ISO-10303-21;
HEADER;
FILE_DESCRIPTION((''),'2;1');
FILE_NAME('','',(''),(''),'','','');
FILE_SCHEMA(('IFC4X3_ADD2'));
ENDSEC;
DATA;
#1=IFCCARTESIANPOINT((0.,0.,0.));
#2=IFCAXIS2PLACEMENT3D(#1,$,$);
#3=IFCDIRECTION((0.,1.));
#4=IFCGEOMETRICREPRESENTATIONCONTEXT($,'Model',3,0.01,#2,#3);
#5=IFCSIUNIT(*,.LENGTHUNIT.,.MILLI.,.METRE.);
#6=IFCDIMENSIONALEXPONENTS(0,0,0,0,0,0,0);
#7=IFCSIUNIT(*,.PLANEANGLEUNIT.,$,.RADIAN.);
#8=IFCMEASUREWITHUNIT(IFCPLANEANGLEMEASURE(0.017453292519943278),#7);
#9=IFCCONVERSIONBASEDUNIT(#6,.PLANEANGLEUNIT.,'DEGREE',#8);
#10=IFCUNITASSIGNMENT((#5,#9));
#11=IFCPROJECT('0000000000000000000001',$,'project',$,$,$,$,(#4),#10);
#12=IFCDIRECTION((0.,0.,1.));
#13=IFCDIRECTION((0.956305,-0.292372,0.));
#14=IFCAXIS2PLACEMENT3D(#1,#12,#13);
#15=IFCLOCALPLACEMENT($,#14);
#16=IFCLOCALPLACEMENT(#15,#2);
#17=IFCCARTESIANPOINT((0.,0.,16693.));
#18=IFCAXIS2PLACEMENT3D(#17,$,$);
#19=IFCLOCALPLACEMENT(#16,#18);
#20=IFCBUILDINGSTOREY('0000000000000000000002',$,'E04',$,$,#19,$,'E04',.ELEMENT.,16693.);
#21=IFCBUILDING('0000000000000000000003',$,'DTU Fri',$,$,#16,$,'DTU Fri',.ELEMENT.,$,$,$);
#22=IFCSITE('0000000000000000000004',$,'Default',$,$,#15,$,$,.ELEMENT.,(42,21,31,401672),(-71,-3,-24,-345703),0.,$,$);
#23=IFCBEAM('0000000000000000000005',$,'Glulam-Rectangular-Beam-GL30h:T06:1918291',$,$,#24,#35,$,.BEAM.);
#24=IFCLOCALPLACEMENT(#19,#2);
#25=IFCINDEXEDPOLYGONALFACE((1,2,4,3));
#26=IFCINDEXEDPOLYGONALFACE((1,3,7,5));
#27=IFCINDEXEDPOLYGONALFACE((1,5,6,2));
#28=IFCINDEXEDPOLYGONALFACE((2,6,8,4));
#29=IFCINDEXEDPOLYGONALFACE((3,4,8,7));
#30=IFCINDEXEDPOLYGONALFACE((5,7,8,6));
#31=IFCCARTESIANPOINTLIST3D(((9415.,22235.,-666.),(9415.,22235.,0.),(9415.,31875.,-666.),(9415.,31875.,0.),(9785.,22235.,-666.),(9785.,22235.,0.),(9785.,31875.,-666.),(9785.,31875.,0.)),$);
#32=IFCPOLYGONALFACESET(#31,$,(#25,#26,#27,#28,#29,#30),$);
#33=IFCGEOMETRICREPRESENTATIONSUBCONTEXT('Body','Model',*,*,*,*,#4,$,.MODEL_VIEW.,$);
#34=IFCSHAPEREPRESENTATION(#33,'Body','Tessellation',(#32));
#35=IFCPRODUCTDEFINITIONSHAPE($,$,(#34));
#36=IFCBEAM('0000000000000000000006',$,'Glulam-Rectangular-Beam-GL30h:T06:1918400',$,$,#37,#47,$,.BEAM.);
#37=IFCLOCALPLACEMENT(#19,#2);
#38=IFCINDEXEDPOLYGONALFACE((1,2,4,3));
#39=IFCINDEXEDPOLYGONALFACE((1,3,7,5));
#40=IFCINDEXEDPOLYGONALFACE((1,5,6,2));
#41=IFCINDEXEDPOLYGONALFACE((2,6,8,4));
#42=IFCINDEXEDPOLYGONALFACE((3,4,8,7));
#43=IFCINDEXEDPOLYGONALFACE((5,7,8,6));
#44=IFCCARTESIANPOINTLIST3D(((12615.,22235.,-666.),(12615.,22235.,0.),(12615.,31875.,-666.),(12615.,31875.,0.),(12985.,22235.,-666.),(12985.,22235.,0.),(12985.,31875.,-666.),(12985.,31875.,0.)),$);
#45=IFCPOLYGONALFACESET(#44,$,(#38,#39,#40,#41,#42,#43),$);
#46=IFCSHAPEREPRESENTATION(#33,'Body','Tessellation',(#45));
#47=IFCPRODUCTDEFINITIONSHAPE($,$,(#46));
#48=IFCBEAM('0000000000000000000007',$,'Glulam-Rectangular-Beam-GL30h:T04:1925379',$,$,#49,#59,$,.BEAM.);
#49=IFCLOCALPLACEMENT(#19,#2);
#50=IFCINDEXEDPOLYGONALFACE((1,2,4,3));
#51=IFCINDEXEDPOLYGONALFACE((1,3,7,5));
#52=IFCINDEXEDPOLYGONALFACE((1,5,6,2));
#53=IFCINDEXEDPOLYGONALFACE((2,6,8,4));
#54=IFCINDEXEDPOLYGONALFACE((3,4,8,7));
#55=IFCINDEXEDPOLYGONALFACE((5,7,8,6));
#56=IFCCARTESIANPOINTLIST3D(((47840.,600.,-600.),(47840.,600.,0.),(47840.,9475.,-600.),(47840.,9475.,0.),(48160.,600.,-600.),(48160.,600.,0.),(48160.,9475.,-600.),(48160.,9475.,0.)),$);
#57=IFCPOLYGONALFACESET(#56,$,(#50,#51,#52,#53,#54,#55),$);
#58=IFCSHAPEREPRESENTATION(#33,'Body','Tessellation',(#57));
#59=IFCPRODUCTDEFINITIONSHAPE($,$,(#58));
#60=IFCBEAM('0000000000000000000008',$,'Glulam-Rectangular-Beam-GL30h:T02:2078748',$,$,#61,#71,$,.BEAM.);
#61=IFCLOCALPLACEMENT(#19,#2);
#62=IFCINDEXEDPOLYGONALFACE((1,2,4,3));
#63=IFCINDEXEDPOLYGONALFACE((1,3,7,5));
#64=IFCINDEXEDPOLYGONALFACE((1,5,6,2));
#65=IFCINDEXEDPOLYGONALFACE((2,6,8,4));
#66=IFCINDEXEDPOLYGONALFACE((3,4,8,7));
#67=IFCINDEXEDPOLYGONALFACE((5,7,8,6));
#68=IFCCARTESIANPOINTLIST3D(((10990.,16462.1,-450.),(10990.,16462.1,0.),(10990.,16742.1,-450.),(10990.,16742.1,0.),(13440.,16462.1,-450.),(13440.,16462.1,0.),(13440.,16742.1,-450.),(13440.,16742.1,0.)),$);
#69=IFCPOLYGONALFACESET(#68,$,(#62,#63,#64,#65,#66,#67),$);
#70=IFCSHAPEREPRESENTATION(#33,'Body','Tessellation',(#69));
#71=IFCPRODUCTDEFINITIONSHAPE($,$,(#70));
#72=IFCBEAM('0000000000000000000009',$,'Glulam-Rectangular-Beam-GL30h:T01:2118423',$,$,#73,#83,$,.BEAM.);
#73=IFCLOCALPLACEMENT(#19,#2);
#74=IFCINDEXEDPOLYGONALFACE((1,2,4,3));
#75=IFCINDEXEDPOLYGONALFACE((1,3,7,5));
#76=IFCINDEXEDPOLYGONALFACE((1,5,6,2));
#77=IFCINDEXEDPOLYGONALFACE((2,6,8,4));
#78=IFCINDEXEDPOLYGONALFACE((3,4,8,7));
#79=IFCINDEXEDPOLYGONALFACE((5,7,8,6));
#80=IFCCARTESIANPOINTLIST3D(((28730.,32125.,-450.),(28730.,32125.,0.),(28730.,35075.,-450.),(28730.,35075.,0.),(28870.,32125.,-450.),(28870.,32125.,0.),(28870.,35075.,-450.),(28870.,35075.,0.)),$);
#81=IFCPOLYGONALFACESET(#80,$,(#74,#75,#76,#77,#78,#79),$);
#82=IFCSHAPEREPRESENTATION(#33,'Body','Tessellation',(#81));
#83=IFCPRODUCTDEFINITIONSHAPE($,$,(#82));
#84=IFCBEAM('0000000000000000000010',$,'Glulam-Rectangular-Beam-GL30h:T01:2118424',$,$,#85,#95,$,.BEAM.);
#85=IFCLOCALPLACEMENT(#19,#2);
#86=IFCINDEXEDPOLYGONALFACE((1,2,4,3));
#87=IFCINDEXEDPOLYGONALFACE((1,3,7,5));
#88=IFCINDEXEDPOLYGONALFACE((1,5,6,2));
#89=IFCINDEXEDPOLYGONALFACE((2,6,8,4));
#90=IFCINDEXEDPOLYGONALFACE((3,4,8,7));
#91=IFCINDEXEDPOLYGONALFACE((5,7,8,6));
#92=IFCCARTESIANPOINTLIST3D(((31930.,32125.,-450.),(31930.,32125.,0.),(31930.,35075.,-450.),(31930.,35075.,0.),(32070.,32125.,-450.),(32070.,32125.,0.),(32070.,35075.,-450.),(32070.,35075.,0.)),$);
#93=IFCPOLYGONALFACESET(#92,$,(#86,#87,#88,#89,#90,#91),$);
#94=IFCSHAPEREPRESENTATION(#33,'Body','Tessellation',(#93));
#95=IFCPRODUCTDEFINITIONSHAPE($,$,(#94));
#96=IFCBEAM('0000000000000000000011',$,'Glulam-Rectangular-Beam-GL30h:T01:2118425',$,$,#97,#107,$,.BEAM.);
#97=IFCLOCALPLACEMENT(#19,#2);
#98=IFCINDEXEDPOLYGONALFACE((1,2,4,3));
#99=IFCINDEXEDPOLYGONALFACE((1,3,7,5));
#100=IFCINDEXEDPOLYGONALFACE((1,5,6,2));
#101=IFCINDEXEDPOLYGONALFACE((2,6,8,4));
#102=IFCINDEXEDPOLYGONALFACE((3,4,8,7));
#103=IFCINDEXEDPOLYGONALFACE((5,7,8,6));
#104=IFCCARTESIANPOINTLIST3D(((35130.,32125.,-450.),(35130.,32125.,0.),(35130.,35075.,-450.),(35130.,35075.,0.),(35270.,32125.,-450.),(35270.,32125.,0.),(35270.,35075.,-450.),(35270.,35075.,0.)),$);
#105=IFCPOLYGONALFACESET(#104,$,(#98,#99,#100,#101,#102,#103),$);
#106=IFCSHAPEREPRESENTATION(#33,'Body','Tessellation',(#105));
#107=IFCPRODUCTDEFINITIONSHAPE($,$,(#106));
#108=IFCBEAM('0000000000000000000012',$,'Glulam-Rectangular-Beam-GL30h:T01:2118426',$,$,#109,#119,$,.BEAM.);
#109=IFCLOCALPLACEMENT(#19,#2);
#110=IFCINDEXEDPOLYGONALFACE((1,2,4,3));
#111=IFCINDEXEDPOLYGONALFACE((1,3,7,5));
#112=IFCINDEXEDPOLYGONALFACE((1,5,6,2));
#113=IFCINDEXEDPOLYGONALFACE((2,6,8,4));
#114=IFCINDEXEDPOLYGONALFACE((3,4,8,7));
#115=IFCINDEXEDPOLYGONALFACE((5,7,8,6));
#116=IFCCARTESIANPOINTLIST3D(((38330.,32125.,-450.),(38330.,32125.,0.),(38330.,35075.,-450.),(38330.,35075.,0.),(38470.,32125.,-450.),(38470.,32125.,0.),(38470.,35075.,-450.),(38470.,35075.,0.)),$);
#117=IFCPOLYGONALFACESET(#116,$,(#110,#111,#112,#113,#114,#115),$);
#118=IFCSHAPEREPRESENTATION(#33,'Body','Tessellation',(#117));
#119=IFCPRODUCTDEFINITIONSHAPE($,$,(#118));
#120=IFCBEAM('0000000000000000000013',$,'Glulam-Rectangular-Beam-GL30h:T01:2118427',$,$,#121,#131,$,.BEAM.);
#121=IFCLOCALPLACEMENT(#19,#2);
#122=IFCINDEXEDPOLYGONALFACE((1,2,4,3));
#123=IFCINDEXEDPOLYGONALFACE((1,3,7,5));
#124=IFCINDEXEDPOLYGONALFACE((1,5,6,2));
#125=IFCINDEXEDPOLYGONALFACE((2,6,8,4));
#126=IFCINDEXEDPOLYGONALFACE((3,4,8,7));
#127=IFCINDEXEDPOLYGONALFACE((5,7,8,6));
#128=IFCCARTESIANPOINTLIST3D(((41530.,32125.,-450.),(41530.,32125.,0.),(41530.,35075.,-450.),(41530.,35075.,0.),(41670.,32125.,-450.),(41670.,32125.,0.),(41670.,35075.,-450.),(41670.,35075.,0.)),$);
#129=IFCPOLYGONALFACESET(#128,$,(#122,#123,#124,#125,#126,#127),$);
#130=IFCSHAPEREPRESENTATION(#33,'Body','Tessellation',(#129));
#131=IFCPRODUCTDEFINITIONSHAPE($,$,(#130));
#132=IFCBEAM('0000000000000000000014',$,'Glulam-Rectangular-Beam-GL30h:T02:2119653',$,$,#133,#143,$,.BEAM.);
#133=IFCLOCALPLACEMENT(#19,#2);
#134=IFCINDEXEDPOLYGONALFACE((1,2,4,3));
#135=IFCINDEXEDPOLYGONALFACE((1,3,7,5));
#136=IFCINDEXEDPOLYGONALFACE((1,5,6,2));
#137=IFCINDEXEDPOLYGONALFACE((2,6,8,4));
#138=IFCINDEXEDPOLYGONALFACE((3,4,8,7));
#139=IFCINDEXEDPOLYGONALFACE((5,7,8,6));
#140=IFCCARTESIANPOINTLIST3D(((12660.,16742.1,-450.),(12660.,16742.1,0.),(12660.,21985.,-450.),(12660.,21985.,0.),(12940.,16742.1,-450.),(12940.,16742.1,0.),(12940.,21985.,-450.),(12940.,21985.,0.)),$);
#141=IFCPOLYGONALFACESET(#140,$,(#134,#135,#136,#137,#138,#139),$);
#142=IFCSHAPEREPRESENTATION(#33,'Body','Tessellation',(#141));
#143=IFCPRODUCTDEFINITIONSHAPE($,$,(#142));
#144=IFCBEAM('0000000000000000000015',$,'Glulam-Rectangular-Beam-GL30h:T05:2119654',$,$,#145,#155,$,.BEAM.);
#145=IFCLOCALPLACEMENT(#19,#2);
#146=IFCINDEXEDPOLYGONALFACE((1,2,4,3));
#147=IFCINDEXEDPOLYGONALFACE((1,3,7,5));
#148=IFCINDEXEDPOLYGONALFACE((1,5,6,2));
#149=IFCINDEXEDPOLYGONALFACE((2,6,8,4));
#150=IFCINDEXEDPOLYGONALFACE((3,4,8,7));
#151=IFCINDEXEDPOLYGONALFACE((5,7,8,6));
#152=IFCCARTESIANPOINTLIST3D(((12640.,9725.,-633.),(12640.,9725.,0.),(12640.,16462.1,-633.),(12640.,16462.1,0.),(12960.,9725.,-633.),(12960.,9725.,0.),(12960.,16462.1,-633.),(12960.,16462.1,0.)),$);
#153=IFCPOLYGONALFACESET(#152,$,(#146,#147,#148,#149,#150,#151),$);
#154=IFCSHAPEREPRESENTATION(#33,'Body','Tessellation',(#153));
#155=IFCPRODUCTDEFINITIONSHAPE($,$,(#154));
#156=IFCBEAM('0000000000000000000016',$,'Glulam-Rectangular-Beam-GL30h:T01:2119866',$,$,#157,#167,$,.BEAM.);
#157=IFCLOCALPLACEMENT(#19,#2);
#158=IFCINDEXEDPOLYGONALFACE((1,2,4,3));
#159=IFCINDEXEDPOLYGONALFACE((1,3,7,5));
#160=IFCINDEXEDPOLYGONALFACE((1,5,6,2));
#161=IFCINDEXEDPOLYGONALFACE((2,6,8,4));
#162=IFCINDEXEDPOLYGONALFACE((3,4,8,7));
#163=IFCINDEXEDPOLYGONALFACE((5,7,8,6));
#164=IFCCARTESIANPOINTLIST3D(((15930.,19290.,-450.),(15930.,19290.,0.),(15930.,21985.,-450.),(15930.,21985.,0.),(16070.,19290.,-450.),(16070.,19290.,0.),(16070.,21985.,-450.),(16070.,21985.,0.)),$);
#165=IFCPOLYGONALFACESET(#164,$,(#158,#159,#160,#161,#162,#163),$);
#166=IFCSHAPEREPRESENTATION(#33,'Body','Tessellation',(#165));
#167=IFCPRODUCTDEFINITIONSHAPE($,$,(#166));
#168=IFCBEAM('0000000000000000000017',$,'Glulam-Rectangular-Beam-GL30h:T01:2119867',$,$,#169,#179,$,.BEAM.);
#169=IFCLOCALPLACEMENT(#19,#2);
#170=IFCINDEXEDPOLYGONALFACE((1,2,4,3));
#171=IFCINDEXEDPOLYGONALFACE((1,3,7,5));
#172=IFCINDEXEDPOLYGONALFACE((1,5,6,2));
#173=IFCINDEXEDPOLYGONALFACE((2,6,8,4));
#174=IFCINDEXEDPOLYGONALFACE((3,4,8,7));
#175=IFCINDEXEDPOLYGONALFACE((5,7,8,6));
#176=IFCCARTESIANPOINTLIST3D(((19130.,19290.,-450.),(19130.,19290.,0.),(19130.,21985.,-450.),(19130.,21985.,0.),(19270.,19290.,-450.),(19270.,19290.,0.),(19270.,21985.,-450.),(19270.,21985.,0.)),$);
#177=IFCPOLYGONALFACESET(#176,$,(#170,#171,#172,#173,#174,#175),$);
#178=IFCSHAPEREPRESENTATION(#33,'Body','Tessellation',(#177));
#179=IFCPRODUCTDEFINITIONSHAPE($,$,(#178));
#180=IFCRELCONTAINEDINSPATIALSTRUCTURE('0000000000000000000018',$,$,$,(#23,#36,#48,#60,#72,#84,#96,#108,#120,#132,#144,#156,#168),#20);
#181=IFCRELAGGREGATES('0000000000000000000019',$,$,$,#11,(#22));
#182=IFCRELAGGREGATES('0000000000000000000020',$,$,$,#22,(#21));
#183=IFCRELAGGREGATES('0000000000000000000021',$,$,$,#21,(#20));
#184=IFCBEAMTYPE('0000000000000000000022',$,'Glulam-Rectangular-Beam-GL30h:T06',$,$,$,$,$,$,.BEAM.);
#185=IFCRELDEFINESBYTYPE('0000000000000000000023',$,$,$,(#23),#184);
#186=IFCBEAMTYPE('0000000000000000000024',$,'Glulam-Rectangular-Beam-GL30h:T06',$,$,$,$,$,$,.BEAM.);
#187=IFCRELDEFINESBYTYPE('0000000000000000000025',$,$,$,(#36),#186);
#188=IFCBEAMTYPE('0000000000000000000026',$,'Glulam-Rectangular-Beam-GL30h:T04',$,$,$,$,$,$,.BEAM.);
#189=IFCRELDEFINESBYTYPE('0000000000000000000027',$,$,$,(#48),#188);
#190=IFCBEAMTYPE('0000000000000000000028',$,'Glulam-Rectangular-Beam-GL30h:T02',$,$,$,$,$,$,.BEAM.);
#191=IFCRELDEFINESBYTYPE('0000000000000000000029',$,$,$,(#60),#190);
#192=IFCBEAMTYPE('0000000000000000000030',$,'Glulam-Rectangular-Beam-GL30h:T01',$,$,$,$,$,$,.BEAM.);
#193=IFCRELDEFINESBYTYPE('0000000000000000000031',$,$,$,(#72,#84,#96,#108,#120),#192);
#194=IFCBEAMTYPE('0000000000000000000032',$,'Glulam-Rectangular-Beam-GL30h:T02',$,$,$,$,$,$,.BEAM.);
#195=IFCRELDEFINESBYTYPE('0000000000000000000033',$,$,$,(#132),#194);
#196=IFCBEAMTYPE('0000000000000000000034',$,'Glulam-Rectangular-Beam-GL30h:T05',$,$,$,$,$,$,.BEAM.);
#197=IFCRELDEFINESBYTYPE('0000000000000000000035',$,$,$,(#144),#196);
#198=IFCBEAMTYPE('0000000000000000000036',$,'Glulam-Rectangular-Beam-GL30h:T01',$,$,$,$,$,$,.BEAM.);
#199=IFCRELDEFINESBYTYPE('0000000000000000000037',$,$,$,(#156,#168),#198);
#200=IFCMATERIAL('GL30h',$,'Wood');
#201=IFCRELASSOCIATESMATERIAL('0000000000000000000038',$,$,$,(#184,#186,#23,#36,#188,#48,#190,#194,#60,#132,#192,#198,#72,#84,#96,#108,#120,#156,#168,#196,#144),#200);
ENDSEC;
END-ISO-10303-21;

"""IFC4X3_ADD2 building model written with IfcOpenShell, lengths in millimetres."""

from ifc_helpers import new_model, entity, si_unit, converted_unit, direction, frame, origin, origin_2d_with_axis, place, context, subcontext, project, spatial, rectangle, extrude, source, transform, mapped, material, material_profile, profile_set, profile_usage, type_object, type_shapes, element, save


model = new_model("IFC4X3_ADD2")

# Units and contexts
model_context = context("Model", 3, precision=0.01, world=origin(), true_north=direction((0.0, 1.0)))
body_context = subcontext(model_context, "Body", "Model", "MODEL_VIEW")
ifc_project = project(units=[si_unit("LENGTHUNIT", "METRE", prefix="MILLI"), converted_unit("PLANEANGLEUNIT", "DEGREE", entity("IfcPlaneAngleMeasure", 0.017453292519943278), si_unit("PLANEANGLEUNIT", "RADIAN"), dimensions=[0, 0, 0, 0, 0, 0, 0])], contexts=[model_context])

# Site, building, storey
site_placement = place(None, frame((0.0, 0.0, 0.0), z_axis=(0.0, 0.0, 1.0), x_axis=(0.956305, -0.292372, 0.0)))
site = spatial("IfcSite", under=ifc_project, at=site_placement, Name="Default", CompositionType="ELEMENT", RefLatitude=(42, 21, 31, 401672), RefLongitude=(-71, -3, -24, -345703), RefElevation=0.0)
building_placement = place(site_placement, origin())
building = spatial("IfcBuilding", under=site, at=building_placement, Name="DTU Fri", LongName="DTU Fri", CompositionType="ELEMENT")
storey_placement = place(building_placement, frame((0.0, 0.0, 16693.0)))
storey = spatial("IfcBuildingStorey", under=building, at=storey_placement, Name="E04", LongName="E04", CompositionType="ELEMENT", Elevation=16693.0)

# Beams
ifc_material = material(Name="GL30h", Category="Wood")
ifc_material_profile_1 = material_profile(ifc_material, rectangle(XDim=666.0, YDim=370.0, at=origin_2d_with_axis()), Name="T06")
ifc_profile_set_1 = profile_set([ifc_material_profile_1], Name="T06")
ifc_profile_usage_1 = profile_usage(ifc_profile_set_1, cardinal=8)
beam_type_1 = type_object("IfcBeamType", Name="Glulam-Rectangular-Beam-GL30h:T06", PredefinedType="BEAM", material=ifc_profile_set_1)
shared_shape_1 = source(origin(), body_context, "Body", "SweptSolid", [
    extrude(rectangle(XDim=666.0, YDim=370.0, at=origin_2d_with_axis()), frame((-4820.0, 0.0, 0.0), z_axis=(1.0, 0.0, 0.0), x_axis=(0.0, 0.0, -1.0)), (0.0, 0.0, 1.0), 9640.0),
])
type_shapes(beam_type_1, [shared_shape_1])
beam_1_placement = place(storey_placement, frame((9600.0, 27055.0, -333.0), z_axis=(0.0, 0.0, 1.0), x_axis=(0.0, -1.0, 0.0)))
element("IfcBeam", 1, at=beam_1_placement, inside=storey, type_object=beam_type_1, material=ifc_profile_usage_1, Name="Glulam-Rectangular-Beam-GL30h:T06:1918291", PredefinedType="BEAM", context=body_context, shape_type="MappedRepresentation", body=[
    mapped(shared_shape_1, transform((0.0, 0.0, 0.0), scale=1.0)),
])
beam_type_2 = type_object("IfcBeamType", Name="Glulam-Rectangular-Beam-GL30h:T06", PredefinedType="BEAM", material=ifc_profile_set_1)
shared_shape_2 = source(origin(), body_context, "Body", "SweptSolid", [
    extrude(rectangle(XDim=666.0, YDim=370.0, at=origin_2d_with_axis()), frame((-4768.7, 0.0, 0.0), z_axis=(1.0, 0.0, 0.0), x_axis=(0.0, 0.0, -1.0)), (0.0, 0.0, 1.0), 9640.0),
])
type_shapes(beam_type_2, [shared_shape_2])
beam_2_placement = place(storey_placement, frame((12800.0, 27106.3, -333.0), z_axis=(0.0, 0.0, 1.0), x_axis=(-0.000004, -1.0, 0.0)))
element("IfcBeam", 2, at=beam_2_placement, inside=storey, type_object=beam_type_2, material=ifc_profile_usage_1, Name="Glulam-Rectangular-Beam-GL30h:T06:1918400", PredefinedType="BEAM", context=body_context, shape_type="MappedRepresentation", body=[
    mapped(shared_shape_2, transform((0.0, 0.0, 0.0), scale=1.0)),
])
ifc_material_profile_2 = material_profile(ifc_material, rectangle(XDim=600.0, YDim=320.0, at=origin_2d_with_axis()), Name="T04")
ifc_profile_set_2 = profile_set([ifc_material_profile_2], Name="T04")
ifc_profile_usage_2 = profile_usage(ifc_profile_set_2, cardinal=8)
beam_type_3 = type_object("IfcBeamType", Name="Glulam-Rectangular-Beam-GL30h:T04", PredefinedType="BEAM", material=ifc_profile_set_2)
shared_shape_3 = source(origin(), body_context, "Body", "SweptSolid", [
    extrude(rectangle(XDim=600.0, YDim=320.0, at=origin_2d_with_axis()), frame((-4425.0, 0.0, 0.0), z_axis=(1.0, 0.0, 0.0), x_axis=(0.0, 0.0, -1.0)), (0.0, 0.0, 1.0), 8875.0),
])
type_shapes(beam_type_3, [shared_shape_3])
beam_3_placement = place(storey_placement, frame((48000.0, 5050.0, -300.0), z_axis=(0.0, 0.0, 1.0), x_axis=(0.0, -1.0, 0.0)))
element("IfcBeam", 3, at=beam_3_placement, inside=storey, type_object=beam_type_3, material=ifc_profile_usage_2, Name="Glulam-Rectangular-Beam-GL30h:T04:1925379", PredefinedType="BEAM", context=body_context, shape_type="MappedRepresentation", body=[
    mapped(shared_shape_3, transform((0.0, 0.0, 0.0), scale=1.0)),
])
ifc_material_profile_3 = material_profile(ifc_material, rectangle(XDim=450.0, YDim=280.0, at=origin_2d_with_axis()), Name="T02")
ifc_profile_set_3 = profile_set([ifc_material_profile_3], Name="T02")
ifc_profile_usage_3 = profile_usage(ifc_profile_set_3, cardinal=8)
beam_type_4 = type_object("IfcBeamType", Name="Glulam-Rectangular-Beam-GL30h:T02", PredefinedType="BEAM", material=ifc_profile_set_3)
shared_shape_4 = source(origin(), body_context, "Body", "SweptSolid", [
    extrude(rectangle(XDim=450.0, YDim=280.0, at=origin_2d_with_axis()), frame((-1225.0, 0.0, 0.0), z_axis=(1.0, 0.0, 0.0), x_axis=(0.0, 0.0, -1.0)), (0.0, 0.0, 1.0), 2450.0),
])
type_shapes(beam_type_4, [shared_shape_4])
beam_4_placement = place(storey_placement, frame((12215.0, 16602.1, -225.0), z_axis=(0.0, 0.0, 1.0), x_axis=(-1.0, 0.0, 0.0)))
element("IfcBeam", 4, at=beam_4_placement, inside=storey, type_object=beam_type_4, material=ifc_profile_usage_3, Name="Glulam-Rectangular-Beam-GL30h:T02:2078748", PredefinedType="BEAM", context=body_context, shape_type="MappedRepresentation", body=[
    mapped(shared_shape_4, transform((0.0, 0.0, 0.0), scale=1.0)),
])
ifc_material_profile_4 = material_profile(ifc_material, rectangle(XDim=450.0, YDim=140.0, at=origin_2d_with_axis()), Name="T01")
ifc_profile_set_4 = profile_set([ifc_material_profile_4], Name="T01")
ifc_profile_usage_4 = profile_usage(ifc_profile_set_4, cardinal=8)
beam_type_5 = type_object("IfcBeamType", Name="Glulam-Rectangular-Beam-GL30h:T01", PredefinedType="BEAM", material=ifc_profile_set_4)
shared_shape_5 = source(origin(), body_context, "Body", "SweptSolid", [
    extrude(rectangle(XDim=450.0, YDim=140.0, at=origin_2d_with_axis()), frame((-1475.0, 0.0, 0.0), z_axis=(1.0, 0.0, 0.0), x_axis=(0.0, 0.0, -1.0)), (0.0, 0.0, 1.0), 2950.0),
])
type_shapes(beam_type_5, [shared_shape_5])
for number, where, z_axis, x_axis, name in (
    (5, (28800.0, 33600.0, -225.0), (0.0, 0.0, 1.0), (0.0, 1.0, 0.0), "Glulam-Rectangular-Beam-GL30h:T01:2118423"),
    (6, (32000.0, 33600.0, -225.0), (0.0, 0.0, 1.0), (0.0, 1.0, 0.0), "Glulam-Rectangular-Beam-GL30h:T01:2118424"),
    (7, (35200.0, 33600.0, -225.0), (0.0, 0.0, 1.0), (0.0, 1.0, 0.0), "Glulam-Rectangular-Beam-GL30h:T01:2118425"),
    (8, (38400.0, 33600.0, -225.0), (0.0, 0.0, 1.0), (0.0, 1.0, 0.0), "Glulam-Rectangular-Beam-GL30h:T01:2118426"),
    (9, (41600.0, 33600.0, -225.0), (0.0, 0.0, 1.0), (0.0, 1.0, 0.0), "Glulam-Rectangular-Beam-GL30h:T01:2118427"),
):
    element("IfcBeam", number, at=place(storey_placement, frame(where, z_axis=z_axis, x_axis=x_axis)), inside=storey, type_object=beam_type_5, material=ifc_profile_usage_4, Name=name, PredefinedType="BEAM", context=body_context, shape_type="MappedRepresentation", body=[
        mapped(shared_shape_5, transform((0.0, 0.0, 0.0), scale=1.0)),
    ])
beam_type_6 = type_object("IfcBeamType", Name="Glulam-Rectangular-Beam-GL30h:T02", PredefinedType="BEAM", material=ifc_profile_set_3)
shared_shape_6 = source(origin(), body_context, "Body", "SweptSolid", [
    extrude(rectangle(XDim=450.0, YDim=280.0, at=origin_2d_with_axis()), frame((-2614.0, 0.0, 0.0), z_axis=(1.0, 0.0, 0.0), x_axis=(0.0, 0.0, -1.0)), (0.0, 0.0, 1.0), 5242.9),
])
type_shapes(beam_type_6, [shared_shape_6])
beam_5_placement = place(storey_placement, frame((12800.0, 19356.0, -225.0), z_axis=(0.0, 0.0, 1.0), x_axis=(0.0, 1.0, 0.0)))
element("IfcBeam", 10, at=beam_5_placement, inside=storey, type_object=beam_type_6, material=ifc_profile_usage_3, Name="Glulam-Rectangular-Beam-GL30h:T02:2119653", PredefinedType="BEAM", context=body_context, shape_type="MappedRepresentation", body=[
    mapped(shared_shape_6, transform((0.0, 0.0, 0.0), scale=1.0)),
])
ifc_material_profile_5 = material_profile(ifc_material, rectangle(XDim=633.0, YDim=320.0, at=origin_2d_with_axis()), Name="T05")
ifc_profile_set_5 = profile_set([ifc_material_profile_5], Name="T05")
ifc_profile_usage_5 = profile_usage(ifc_profile_set_5, cardinal=8)
beam_type_7 = type_object("IfcBeamType", Name="Glulam-Rectangular-Beam-GL30h:T05", PredefinedType="BEAM", material=ifc_profile_set_5)
shared_shape_7 = source(origin(), body_context, "Body", "SweptSolid", [
    extrude(rectangle(XDim=633.0, YDim=320.0, at=origin_2d_with_axis()), frame((-3376.0, 0.0, 0.0), z_axis=(1.0, 0.0, 0.0), x_axis=(0.0, 0.0, -1.0)), (0.0, 0.0, 1.0), 6737.1),
])
type_shapes(beam_type_7, [shared_shape_7])
beam_6_placement = place(storey_placement, frame((12800.0, 13101.0, -316.5), z_axis=(0.0, 0.0, 1.0), x_axis=(0.0, 1.0, 0.0)))
element("IfcBeam", 11, at=beam_6_placement, inside=storey, type_object=beam_type_7, material=ifc_profile_usage_5, Name="Glulam-Rectangular-Beam-GL30h:T05:2119654", PredefinedType="BEAM", context=body_context, shape_type="MappedRepresentation", body=[
    mapped(shared_shape_7, transform((0.0, 0.0, 0.0), scale=1.0)),
])
beam_type_8 = type_object("IfcBeamType", Name="Glulam-Rectangular-Beam-GL30h:T01", PredefinedType="BEAM", material=ifc_profile_set_4)
shared_shape_8 = source(origin(), body_context, "Body", "SweptSolid", [
    extrude(rectangle(XDim=450.0, YDim=140.0, at=origin_2d_with_axis()), frame((-1365.0, 0.0, 0.0), z_axis=(1.0, 0.0, 0.0), x_axis=(0.0, 0.0, -1.0)), (0.0, 0.0, 1.0), 2695.0),
])
type_shapes(beam_type_8, [shared_shape_8])
for number, where, z_axis, x_axis, name in (
    (12, (16000.0, 20655.0, -225.0), (0.0, 0.0, 1.0), (0.0, 1.0, 0.0), "Glulam-Rectangular-Beam-GL30h:T01:2119866"),
    (13, (19200.0, 20655.0, -225.0), (0.0, 0.0, 1.0), (0.0, 1.0, 0.0), "Glulam-Rectangular-Beam-GL30h:T01:2119867"),
):
    element("IfcBeam", number, at=place(storey_placement, frame(where, z_axis=z_axis, x_axis=x_axis)), inside=storey, type_object=beam_type_8, material=ifc_profile_usage_4, Name=name, PredefinedType="BEAM", context=body_context, shape_type="MappedRepresentation", body=[
        mapped(shared_shape_8, transform((0.0, 0.0, 0.0), scale=1.0)),
    ])

save(model, "model.ifc")
